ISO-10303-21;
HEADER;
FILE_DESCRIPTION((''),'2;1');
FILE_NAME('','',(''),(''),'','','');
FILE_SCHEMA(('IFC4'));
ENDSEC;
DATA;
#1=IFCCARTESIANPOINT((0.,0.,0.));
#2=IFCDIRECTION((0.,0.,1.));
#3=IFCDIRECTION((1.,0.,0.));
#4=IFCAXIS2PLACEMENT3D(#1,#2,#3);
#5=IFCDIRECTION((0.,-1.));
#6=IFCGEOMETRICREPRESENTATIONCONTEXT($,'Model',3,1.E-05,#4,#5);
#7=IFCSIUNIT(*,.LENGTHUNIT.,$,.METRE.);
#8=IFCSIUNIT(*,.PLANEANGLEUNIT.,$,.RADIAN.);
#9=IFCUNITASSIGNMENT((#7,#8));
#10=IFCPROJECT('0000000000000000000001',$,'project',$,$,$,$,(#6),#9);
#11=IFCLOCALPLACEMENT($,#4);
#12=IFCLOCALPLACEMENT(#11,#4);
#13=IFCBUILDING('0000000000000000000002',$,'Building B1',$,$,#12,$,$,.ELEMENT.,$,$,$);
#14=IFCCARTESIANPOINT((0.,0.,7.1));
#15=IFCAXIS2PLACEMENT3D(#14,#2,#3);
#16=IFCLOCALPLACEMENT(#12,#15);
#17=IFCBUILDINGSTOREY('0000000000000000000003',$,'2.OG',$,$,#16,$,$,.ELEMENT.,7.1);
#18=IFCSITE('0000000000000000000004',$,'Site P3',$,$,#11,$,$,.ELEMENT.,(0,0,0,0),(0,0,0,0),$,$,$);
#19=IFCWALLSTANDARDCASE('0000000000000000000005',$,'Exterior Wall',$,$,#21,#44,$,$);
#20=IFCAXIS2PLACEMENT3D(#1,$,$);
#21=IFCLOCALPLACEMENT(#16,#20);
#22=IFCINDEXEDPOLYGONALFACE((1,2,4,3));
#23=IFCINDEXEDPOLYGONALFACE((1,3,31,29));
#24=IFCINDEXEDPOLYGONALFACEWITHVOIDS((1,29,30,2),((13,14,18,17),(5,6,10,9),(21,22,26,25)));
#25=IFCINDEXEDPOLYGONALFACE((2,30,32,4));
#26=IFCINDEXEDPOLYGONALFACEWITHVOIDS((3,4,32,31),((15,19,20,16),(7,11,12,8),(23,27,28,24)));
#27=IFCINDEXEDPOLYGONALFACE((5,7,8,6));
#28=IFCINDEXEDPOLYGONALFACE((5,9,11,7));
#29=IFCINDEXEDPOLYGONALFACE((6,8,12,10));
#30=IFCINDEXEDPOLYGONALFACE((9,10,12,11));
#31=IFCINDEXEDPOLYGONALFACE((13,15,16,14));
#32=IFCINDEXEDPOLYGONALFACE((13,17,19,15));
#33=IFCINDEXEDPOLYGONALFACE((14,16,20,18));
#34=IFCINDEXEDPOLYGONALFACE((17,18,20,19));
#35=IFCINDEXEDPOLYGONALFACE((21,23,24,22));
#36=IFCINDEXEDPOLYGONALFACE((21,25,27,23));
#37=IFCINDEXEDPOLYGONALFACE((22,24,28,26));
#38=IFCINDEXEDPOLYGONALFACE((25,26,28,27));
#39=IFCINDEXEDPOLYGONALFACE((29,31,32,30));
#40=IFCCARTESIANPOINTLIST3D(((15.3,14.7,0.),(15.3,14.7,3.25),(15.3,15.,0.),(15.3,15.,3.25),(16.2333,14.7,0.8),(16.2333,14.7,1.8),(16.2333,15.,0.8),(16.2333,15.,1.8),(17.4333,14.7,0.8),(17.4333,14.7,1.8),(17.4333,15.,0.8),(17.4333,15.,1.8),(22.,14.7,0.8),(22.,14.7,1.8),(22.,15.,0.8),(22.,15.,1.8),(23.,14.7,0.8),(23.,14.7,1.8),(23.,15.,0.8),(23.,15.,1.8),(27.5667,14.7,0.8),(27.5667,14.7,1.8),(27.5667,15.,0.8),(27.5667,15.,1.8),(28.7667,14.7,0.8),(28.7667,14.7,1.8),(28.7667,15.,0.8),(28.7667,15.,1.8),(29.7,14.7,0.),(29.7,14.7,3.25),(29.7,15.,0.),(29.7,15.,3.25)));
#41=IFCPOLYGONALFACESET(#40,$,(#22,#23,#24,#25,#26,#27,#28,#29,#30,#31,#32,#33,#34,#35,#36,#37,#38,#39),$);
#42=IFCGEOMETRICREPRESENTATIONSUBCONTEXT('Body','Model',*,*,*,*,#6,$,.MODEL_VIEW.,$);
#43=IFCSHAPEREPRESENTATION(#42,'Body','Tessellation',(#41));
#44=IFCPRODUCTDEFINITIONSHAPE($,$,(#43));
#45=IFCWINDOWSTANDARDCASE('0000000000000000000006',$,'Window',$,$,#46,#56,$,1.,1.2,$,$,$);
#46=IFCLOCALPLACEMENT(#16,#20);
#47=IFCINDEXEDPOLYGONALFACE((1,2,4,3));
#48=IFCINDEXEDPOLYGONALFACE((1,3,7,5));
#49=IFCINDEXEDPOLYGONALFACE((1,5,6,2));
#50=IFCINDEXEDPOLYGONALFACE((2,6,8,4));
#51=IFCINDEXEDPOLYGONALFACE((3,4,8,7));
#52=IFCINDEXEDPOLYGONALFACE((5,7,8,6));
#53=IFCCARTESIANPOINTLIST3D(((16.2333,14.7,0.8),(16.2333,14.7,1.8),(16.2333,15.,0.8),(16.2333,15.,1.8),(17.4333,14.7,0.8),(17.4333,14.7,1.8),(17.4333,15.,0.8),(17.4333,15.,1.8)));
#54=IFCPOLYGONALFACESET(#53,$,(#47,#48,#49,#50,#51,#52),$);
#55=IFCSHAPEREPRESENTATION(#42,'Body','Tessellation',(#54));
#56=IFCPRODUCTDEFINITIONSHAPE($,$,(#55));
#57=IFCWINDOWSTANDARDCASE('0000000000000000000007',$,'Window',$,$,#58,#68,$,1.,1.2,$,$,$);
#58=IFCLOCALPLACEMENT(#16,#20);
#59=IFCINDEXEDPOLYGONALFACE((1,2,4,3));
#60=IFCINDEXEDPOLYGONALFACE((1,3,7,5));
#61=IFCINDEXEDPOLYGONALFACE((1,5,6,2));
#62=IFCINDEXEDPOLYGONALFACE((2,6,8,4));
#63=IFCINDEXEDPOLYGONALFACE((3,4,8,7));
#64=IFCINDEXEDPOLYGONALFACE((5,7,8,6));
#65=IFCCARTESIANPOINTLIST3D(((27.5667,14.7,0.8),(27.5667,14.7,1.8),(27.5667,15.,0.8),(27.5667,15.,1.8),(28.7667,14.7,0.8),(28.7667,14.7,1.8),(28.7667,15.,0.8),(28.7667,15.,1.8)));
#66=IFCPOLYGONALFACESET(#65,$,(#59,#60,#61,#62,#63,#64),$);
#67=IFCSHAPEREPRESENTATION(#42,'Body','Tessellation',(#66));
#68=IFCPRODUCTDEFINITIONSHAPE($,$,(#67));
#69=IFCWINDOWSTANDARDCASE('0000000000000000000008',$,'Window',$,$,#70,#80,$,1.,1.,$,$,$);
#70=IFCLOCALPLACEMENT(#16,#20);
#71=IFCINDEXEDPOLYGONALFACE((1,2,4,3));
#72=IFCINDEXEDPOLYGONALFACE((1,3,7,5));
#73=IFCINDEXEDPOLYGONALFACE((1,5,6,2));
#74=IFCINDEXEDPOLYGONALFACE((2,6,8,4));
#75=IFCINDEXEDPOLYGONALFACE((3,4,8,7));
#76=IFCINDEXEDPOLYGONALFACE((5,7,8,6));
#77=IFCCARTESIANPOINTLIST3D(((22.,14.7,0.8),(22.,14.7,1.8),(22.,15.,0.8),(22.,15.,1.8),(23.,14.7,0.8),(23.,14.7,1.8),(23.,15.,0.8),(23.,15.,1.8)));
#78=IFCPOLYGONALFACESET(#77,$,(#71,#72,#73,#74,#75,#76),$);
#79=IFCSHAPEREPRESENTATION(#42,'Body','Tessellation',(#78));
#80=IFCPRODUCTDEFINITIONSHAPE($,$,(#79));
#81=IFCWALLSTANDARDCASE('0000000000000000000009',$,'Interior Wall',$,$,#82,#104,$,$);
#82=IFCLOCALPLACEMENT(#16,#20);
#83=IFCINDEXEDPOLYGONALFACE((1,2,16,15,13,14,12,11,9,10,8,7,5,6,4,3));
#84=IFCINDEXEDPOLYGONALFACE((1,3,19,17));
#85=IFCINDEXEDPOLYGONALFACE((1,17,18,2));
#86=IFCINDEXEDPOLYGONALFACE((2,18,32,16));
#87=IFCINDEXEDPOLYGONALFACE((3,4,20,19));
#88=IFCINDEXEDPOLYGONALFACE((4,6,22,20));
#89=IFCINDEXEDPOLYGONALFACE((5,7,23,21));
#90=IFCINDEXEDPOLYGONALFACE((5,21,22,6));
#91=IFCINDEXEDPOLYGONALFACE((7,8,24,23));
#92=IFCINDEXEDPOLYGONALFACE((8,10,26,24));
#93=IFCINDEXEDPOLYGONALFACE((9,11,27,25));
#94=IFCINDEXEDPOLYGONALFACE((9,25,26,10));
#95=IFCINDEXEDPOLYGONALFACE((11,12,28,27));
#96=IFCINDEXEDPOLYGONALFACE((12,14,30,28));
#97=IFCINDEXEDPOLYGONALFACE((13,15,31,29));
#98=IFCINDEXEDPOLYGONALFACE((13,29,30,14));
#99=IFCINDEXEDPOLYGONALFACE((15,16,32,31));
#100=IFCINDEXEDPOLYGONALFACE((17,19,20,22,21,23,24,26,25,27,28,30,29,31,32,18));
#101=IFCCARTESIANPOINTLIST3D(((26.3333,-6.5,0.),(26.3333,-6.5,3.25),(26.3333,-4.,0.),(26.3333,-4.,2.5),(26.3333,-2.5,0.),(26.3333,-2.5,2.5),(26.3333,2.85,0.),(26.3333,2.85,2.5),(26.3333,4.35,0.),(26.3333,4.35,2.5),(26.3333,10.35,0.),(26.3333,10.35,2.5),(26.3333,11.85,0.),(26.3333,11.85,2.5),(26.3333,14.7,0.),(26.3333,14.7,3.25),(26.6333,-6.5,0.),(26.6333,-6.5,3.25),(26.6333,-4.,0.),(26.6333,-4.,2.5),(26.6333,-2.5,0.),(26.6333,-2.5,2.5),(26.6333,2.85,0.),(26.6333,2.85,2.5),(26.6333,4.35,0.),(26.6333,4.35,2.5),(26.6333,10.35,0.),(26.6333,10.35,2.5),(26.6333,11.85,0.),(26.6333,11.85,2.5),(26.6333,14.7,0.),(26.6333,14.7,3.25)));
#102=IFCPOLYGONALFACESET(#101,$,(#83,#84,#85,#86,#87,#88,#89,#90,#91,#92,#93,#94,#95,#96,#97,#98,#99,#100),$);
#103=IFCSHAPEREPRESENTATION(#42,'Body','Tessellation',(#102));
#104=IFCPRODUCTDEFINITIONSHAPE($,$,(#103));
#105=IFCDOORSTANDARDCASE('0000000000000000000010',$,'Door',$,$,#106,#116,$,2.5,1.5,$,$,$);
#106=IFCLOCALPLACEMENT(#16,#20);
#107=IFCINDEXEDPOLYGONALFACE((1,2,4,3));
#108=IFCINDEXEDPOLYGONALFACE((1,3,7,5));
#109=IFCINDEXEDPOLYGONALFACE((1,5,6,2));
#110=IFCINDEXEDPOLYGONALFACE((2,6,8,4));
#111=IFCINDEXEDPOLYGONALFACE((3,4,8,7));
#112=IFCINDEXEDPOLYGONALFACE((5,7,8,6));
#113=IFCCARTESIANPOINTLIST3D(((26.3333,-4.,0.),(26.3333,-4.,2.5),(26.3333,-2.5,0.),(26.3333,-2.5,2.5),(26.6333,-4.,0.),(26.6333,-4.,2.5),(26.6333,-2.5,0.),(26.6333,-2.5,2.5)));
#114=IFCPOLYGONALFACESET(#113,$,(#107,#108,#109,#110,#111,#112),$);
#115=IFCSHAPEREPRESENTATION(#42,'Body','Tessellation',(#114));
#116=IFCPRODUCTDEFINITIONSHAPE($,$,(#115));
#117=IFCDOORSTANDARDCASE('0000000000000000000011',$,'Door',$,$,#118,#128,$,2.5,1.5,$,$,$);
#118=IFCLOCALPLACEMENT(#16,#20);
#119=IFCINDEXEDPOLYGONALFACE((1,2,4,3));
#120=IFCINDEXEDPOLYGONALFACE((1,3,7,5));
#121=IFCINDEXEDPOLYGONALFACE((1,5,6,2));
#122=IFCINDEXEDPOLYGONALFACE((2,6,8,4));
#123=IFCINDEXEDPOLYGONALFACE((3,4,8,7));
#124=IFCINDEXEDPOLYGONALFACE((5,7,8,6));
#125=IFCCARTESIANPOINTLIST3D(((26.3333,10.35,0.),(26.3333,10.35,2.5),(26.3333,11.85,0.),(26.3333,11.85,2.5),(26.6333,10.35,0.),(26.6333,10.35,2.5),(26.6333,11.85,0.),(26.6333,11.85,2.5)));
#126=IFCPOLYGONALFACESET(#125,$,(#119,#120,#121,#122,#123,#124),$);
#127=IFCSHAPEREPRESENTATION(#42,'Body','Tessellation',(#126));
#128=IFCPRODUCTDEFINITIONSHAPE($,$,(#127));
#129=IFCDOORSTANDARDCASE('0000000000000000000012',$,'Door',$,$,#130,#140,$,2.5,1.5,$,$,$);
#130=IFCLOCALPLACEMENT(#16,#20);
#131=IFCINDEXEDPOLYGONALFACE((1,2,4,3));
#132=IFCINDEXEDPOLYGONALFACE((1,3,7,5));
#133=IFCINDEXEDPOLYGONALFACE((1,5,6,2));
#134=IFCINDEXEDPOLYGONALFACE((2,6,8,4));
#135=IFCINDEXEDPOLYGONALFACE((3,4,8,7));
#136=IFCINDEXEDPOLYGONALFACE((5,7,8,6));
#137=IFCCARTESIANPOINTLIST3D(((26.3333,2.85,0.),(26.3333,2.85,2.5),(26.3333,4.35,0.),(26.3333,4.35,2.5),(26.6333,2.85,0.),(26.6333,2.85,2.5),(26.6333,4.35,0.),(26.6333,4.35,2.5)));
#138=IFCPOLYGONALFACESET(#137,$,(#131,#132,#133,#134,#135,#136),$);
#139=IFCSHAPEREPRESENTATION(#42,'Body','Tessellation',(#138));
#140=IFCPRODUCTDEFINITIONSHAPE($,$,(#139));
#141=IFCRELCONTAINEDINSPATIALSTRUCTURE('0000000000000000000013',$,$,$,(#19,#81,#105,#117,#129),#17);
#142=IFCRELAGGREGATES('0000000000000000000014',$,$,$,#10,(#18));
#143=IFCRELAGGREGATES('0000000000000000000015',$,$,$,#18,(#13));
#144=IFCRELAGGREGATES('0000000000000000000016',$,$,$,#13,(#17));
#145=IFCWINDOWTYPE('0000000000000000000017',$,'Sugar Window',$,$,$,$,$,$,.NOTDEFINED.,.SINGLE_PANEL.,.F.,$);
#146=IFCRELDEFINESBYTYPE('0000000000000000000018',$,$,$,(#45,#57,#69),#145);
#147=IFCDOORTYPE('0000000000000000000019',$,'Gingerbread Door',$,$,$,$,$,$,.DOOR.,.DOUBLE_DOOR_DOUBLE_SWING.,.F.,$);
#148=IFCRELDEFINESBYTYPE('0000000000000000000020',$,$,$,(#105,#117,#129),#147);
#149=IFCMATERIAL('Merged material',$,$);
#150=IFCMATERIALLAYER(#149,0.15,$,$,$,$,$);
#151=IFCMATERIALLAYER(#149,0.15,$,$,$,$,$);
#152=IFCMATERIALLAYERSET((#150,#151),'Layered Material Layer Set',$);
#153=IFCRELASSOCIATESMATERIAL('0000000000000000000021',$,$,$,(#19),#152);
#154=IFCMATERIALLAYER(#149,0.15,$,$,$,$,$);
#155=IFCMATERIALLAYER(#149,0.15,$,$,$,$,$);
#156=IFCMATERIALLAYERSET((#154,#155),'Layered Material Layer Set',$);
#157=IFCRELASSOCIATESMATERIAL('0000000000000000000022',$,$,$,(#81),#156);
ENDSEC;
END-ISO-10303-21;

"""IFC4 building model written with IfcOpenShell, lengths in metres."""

from ifc_helpers import new_model, si_unit, direction, frame, origin_with_axes, place, context, subcontext, project, spatial, polyline, outline, extrude, source, transform, mapped, material, layer, layer_set, layer_usage, type_object, element, fill, save


model = new_model("IFC4")

# Units and contexts
model_context = context("Model", 3, precision=1e-05, world=origin_with_axes(), true_north=direction((0.0, -1.0)))
body_context = subcontext(model_context, "Body", "Model", "MODEL_VIEW")
ifc_project = project(units=[si_unit("LENGTHUNIT", "METRE"), si_unit("PLANEANGLEUNIT", "RADIAN")], contexts=[model_context])

# Site, building, storey
site_placement = place(None, origin_with_axes())
site = spatial("IfcSite", under=ifc_project, at=site_placement, Name="Site P3", CompositionType="ELEMENT", RefLatitude=(0, 0, 0, 0), RefLongitude=(0, 0, 0, 0))
building_placement = place(site_placement, origin_with_axes())
building = spatial("IfcBuilding", under=site, at=building_placement, Name="Building B1", CompositionType="ELEMENT")
storey_placement = place(building_placement, frame((0.0, 0.0, 7.1), z_axis=(0.0, 0.0, 1.0), x_axis=(1.0, 0.0, 0.0)))
storey = spatial("IfcBuildingStorey", under=building, at=storey_placement, Name="2.OG", CompositionType="ELEMENT", Elevation=7.1)

# Wall, openings, windows
ifc_material = material(Name="Merged material")
ifc_layer_1 = layer(ifc_material, 0.15)
ifc_layer_2 = layer(ifc_material, 0.15)
ifc_layer_set_1 = layer_set([ifc_layer_1, ifc_layer_2], Name="Layered Material Layer Set")
ifc_layer_usage_1 = layer_usage(ifc_layer_set_1, "AXIS2", "POSITIVE", -0.15)
wall_1_placement = place(storey_placement, frame((29.7, 14.85, 0.0), z_axis=(0.0, 0.0, 1.0), x_axis=(-1.0, 0.0, 0.0)))
wall_1 = element("IfcWallStandardCase", 1, at=wall_1_placement, inside=storey, material=ifc_layer_usage_1, Name="Exterior Wall", context=body_context, shape_type="SweptSolid", body=[
    extrude(outline(polyline([(0.0, 0.15), (14.4, 0.15), (14.4, -0.15), (0.0, -0.15), (0.0, 0.15)])), origin_with_axes(), (0.0, 0.0, 1.0), 3.25),
])
opening_1_placement = place(wall_1_placement, frame((12.2667, 0.0, 0.8), z_axis=(0.0, 0.0, 1.0), x_axis=(1.0, 0.0, 0.0)))
opening_1 = element("IfcOpeningStandardCase", 2, at=opening_1_placement, cuts=wall_1, context=body_context, shape_type="SweptSolid", body=[
    extrude(outline(polyline([(0.0, 0.0), (0.0, 1.2), (1.0, 1.2), (1.0, 0.0), (0.0, 0.0)])), frame((0.0, -0.15, 0.0), z_axis=(0.0, 1.0, 0.0), x_axis=(0.0, 0.0, 1.0)), (0.0, 0.0, 1.0), 0.3),
])
opening_2_placement = place(wall_1_placement, frame((6.7, 0.0, 0.8), z_axis=(0.0, 0.0, 1.0), x_axis=(1.0, 0.0, 0.0)))
opening_2 = element("IfcOpeningStandardCase", 3, at=opening_2_placement, cuts=wall_1, context=body_context, shape_type="SweptSolid", body=[
    extrude(outline(polyline([(0.0, 0.0), (0.0, 1.0), (1.0, 1.0), (1.0, 0.0), (0.0, 0.0)])), frame((0.0, -0.15, 0.0), z_axis=(0.0, 1.0, 0.0), x_axis=(0.0, 0.0, 1.0)), (0.0, 0.0, 1.0), 0.3),
])
opening_3_placement = place(wall_1_placement, frame((0.9333, 0.0, 0.8), z_axis=(0.0, 0.0, 1.0), x_axis=(1.0, 0.0, 0.0)))
opening_3 = element("IfcOpeningStandardCase", 4, at=opening_3_placement, cuts=wall_1, context=body_context, shape_type="SweptSolid", body=[
    extrude(outline(polyline([(0.0, 0.0), (0.0, 1.2), (1.0, 1.2), (1.0, 0.0), (0.0, 0.0)])), frame((0.0, -0.15, 0.0), z_axis=(0.0, 1.0, 0.0), x_axis=(0.0, 0.0, 1.0)), (0.0, 0.0, 1.0), 0.3),
])
window_type = type_object("IfcWindowType", Name="Sugar Window", ParameterTakesPrecedence=False, PartitioningType="SINGLE_PANEL", PredefinedType="NOTDEFINED")
shared_shape_1 = source(origin_with_axes(), body_context, "Body", "SweptSolid", [
    extrude(outline(polyline([(0.0, 0.0), (0.0, 1.2), (1.0, 1.2), (1.0, 0.0), (0.0, 0.0)])), frame((0.0, -0.15, 0.0), z_axis=(0.0, 1.0, 0.0), x_axis=(0.0, 0.0, 1.0)), (0.0, 0.0, 1.0), 0.3),
])
window_1_placement = place(opening_1_placement, origin_with_axes())
window_1 = element("IfcWindowStandardCase", 5, at=window_1_placement, type_object=window_type, Name="Window", OverallHeight=1.0, OverallWidth=1.2, context=body_context, shape_type="MappedRepresentation", body=[
    mapped(shared_shape_1, transform((0.0, 0.0, 0.0))),
])
fill(opening_1, window_1)
window_2_placement = place(opening_3_placement, origin_with_axes())
window_2 = element("IfcWindowStandardCase", 6, at=window_2_placement, type_object=window_type, Name="Window", OverallHeight=1.0, OverallWidth=1.2, context=body_context, shape_type="MappedRepresentation", body=[
    mapped(shared_shape_1, transform((0.0, 0.0, 0.0))),
])
fill(opening_3, window_2)
shared_shape_2 = source(origin_with_axes(), body_context, "Body", "SweptSolid", [
    extrude(outline(polyline([(0.0, 0.0), (0.0, 1.0), (1.0, 1.0), (1.0, 0.0), (0.0, 0.0)])), frame((0.0, -0.15, 0.0), z_axis=(0.0, 1.0, 0.0), x_axis=(0.0, 0.0, 1.0)), (0.0, 0.0, 1.0), 0.3),
])
window_3_placement = place(opening_2_placement, origin_with_axes())
window_3 = element("IfcWindowStandardCase", 7, at=window_3_placement, type_object=window_type, Name="Window", OverallHeight=1.0, OverallWidth=1.0, context=body_context, shape_type="MappedRepresentation", body=[
    mapped(shared_shape_2, transform((0.0, 0.0, 0.0))),
])
fill(opening_2, window_3)

# Wall, openings, doors
ifc_layer_3 = layer(ifc_material, 0.15)
ifc_layer_4 = layer(ifc_material, 0.15)
ifc_layer_set_2 = layer_set([ifc_layer_3, ifc_layer_4], Name="Layered Material Layer Set")
ifc_layer_usage_2 = layer_usage(ifc_layer_set_2, "AXIS2", "POSITIVE", -0.15)
wall_2_placement = place(storey_placement, frame((26.4833, 14.7, 0.0), z_axis=(0.0, 0.0, 1.0), x_axis=(0.0, -1.0, 0.0)))
wall_2 = element("IfcWallStandardCase", 8, at=wall_2_placement, inside=storey, material=ifc_layer_usage_2, Name="Interior Wall", context=body_context, shape_type="SweptSolid", body=[
    extrude(outline(polyline([(0.0, 0.15), (21.2, 0.15), (21.2, -0.15), (0.0, -0.15), (0.0, 0.15)])), origin_with_axes(), (0.0, 0.0, 1.0), 3.25),
])
opening_4_placement = place(wall_2_placement, frame((17.2, 0.0, 0.0), z_axis=(0.0, 0.0, 1.0), x_axis=(1.0, 0.0, 0.0)))
opening_4 = element("IfcOpeningStandardCase", 9, at=opening_4_placement, cuts=wall_2, context=body_context, shape_type="SweptSolid", body=[
    extrude(outline(polyline([(0.0, 0.0), (0.0, 1.5), (2.5, 1.5), (2.5, 0.0), (0.0, 0.0)])), frame((0.0, -0.15, 0.0), z_axis=(0.0, 1.0, 0.0), x_axis=(0.0, 0.0, 1.0)), (0.0, 0.0, 1.0), 0.3),
])
opening_5_placement = place(wall_2_placement, frame((2.85, 0.0, 0.0), z_axis=(0.0, 0.0, 1.0), x_axis=(1.0, 0.0, 0.0)))
opening_5 = element("IfcOpeningStandardCase", 10, at=opening_5_placement, cuts=wall_2, context=body_context, shape_type="SweptSolid", body=[
    extrude(outline(polyline([(0.0, 0.0), (0.0, 1.5), (2.5, 1.5), (2.5, 0.0), (0.0, 0.0)])), frame((0.0, -0.15, 0.0), z_axis=(0.0, 1.0, 0.0), x_axis=(0.0, 0.0, 1.0)), (0.0, 0.0, 1.0), 0.3),
])
opening_6_placement = place(wall_2_placement, frame((10.35, 0.0, 0.0), z_axis=(0.0, 0.0, 1.0), x_axis=(1.0, 0.0, 0.0)))
opening_6 = element("IfcOpeningStandardCase", 11, at=opening_6_placement, cuts=wall_2, context=body_context, shape_type="SweptSolid", body=[
    extrude(outline(polyline([(0.0, 0.0), (0.0, 1.5), (2.5, 1.5), (2.5, 0.0), (0.0, 0.0)])), frame((0.0, -0.15, 0.0), z_axis=(0.0, 1.0, 0.0), x_axis=(0.0, 0.0, 1.0)), (0.0, 0.0, 1.0), 0.3),
])
door_type = type_object("IfcDoorType", Name="Gingerbread Door", OperationType="DOUBLE_DOOR_DOUBLE_SWING", ParameterTakesPrecedence=False, PredefinedType="DOOR")
shared_shape_3 = source(origin_with_axes(), body_context, "Body", "SweptSolid", [
    extrude(outline(polyline([(0.0, 0.0), (0.0, 1.5), (2.5, 1.5), (2.5, 0.0), (0.0, 0.0)])), frame((0.0, -0.15, 0.0), z_axis=(0.0, 1.0, 0.0), x_axis=(0.0, 0.0, 1.0)), (0.0, 0.0, 1.0), 0.3),
])
door_1_placement = place(opening_4_placement, origin_with_axes())
door_1 = element("IfcDoorStandardCase", 12, at=door_1_placement, inside=storey, type_object=door_type, Name="Door", OverallHeight=2.5, OverallWidth=1.5, context=body_context, shape_type="MappedRepresentation", body=[
    mapped(shared_shape_3, transform((0.0, 0.0, 0.0))),
])
fill(opening_4, door_1)
door_2_placement = place(opening_5_placement, origin_with_axes())
door_2 = element("IfcDoorStandardCase", 13, at=door_2_placement, inside=storey, type_object=door_type, Name="Door", OverallHeight=2.5, OverallWidth=1.5, context=body_context, shape_type="MappedRepresentation", body=[
    mapped(shared_shape_3, transform((0.0, 0.0, 0.0))),
])
fill(opening_5, door_2)
door_3_placement = place(opening_6_placement, origin_with_axes())
door_3 = element("IfcDoorStandardCase", 14, at=door_3_placement, inside=storey, type_object=door_type, Name="Door", OverallHeight=2.5, OverallWidth=1.5, context=body_context, shape_type="MappedRepresentation", body=[
    mapped(shared_shape_3, transform((0.0, 0.0, 0.0))),
])
fill(opening_6, door_3)

save(model, "model.ifc")
